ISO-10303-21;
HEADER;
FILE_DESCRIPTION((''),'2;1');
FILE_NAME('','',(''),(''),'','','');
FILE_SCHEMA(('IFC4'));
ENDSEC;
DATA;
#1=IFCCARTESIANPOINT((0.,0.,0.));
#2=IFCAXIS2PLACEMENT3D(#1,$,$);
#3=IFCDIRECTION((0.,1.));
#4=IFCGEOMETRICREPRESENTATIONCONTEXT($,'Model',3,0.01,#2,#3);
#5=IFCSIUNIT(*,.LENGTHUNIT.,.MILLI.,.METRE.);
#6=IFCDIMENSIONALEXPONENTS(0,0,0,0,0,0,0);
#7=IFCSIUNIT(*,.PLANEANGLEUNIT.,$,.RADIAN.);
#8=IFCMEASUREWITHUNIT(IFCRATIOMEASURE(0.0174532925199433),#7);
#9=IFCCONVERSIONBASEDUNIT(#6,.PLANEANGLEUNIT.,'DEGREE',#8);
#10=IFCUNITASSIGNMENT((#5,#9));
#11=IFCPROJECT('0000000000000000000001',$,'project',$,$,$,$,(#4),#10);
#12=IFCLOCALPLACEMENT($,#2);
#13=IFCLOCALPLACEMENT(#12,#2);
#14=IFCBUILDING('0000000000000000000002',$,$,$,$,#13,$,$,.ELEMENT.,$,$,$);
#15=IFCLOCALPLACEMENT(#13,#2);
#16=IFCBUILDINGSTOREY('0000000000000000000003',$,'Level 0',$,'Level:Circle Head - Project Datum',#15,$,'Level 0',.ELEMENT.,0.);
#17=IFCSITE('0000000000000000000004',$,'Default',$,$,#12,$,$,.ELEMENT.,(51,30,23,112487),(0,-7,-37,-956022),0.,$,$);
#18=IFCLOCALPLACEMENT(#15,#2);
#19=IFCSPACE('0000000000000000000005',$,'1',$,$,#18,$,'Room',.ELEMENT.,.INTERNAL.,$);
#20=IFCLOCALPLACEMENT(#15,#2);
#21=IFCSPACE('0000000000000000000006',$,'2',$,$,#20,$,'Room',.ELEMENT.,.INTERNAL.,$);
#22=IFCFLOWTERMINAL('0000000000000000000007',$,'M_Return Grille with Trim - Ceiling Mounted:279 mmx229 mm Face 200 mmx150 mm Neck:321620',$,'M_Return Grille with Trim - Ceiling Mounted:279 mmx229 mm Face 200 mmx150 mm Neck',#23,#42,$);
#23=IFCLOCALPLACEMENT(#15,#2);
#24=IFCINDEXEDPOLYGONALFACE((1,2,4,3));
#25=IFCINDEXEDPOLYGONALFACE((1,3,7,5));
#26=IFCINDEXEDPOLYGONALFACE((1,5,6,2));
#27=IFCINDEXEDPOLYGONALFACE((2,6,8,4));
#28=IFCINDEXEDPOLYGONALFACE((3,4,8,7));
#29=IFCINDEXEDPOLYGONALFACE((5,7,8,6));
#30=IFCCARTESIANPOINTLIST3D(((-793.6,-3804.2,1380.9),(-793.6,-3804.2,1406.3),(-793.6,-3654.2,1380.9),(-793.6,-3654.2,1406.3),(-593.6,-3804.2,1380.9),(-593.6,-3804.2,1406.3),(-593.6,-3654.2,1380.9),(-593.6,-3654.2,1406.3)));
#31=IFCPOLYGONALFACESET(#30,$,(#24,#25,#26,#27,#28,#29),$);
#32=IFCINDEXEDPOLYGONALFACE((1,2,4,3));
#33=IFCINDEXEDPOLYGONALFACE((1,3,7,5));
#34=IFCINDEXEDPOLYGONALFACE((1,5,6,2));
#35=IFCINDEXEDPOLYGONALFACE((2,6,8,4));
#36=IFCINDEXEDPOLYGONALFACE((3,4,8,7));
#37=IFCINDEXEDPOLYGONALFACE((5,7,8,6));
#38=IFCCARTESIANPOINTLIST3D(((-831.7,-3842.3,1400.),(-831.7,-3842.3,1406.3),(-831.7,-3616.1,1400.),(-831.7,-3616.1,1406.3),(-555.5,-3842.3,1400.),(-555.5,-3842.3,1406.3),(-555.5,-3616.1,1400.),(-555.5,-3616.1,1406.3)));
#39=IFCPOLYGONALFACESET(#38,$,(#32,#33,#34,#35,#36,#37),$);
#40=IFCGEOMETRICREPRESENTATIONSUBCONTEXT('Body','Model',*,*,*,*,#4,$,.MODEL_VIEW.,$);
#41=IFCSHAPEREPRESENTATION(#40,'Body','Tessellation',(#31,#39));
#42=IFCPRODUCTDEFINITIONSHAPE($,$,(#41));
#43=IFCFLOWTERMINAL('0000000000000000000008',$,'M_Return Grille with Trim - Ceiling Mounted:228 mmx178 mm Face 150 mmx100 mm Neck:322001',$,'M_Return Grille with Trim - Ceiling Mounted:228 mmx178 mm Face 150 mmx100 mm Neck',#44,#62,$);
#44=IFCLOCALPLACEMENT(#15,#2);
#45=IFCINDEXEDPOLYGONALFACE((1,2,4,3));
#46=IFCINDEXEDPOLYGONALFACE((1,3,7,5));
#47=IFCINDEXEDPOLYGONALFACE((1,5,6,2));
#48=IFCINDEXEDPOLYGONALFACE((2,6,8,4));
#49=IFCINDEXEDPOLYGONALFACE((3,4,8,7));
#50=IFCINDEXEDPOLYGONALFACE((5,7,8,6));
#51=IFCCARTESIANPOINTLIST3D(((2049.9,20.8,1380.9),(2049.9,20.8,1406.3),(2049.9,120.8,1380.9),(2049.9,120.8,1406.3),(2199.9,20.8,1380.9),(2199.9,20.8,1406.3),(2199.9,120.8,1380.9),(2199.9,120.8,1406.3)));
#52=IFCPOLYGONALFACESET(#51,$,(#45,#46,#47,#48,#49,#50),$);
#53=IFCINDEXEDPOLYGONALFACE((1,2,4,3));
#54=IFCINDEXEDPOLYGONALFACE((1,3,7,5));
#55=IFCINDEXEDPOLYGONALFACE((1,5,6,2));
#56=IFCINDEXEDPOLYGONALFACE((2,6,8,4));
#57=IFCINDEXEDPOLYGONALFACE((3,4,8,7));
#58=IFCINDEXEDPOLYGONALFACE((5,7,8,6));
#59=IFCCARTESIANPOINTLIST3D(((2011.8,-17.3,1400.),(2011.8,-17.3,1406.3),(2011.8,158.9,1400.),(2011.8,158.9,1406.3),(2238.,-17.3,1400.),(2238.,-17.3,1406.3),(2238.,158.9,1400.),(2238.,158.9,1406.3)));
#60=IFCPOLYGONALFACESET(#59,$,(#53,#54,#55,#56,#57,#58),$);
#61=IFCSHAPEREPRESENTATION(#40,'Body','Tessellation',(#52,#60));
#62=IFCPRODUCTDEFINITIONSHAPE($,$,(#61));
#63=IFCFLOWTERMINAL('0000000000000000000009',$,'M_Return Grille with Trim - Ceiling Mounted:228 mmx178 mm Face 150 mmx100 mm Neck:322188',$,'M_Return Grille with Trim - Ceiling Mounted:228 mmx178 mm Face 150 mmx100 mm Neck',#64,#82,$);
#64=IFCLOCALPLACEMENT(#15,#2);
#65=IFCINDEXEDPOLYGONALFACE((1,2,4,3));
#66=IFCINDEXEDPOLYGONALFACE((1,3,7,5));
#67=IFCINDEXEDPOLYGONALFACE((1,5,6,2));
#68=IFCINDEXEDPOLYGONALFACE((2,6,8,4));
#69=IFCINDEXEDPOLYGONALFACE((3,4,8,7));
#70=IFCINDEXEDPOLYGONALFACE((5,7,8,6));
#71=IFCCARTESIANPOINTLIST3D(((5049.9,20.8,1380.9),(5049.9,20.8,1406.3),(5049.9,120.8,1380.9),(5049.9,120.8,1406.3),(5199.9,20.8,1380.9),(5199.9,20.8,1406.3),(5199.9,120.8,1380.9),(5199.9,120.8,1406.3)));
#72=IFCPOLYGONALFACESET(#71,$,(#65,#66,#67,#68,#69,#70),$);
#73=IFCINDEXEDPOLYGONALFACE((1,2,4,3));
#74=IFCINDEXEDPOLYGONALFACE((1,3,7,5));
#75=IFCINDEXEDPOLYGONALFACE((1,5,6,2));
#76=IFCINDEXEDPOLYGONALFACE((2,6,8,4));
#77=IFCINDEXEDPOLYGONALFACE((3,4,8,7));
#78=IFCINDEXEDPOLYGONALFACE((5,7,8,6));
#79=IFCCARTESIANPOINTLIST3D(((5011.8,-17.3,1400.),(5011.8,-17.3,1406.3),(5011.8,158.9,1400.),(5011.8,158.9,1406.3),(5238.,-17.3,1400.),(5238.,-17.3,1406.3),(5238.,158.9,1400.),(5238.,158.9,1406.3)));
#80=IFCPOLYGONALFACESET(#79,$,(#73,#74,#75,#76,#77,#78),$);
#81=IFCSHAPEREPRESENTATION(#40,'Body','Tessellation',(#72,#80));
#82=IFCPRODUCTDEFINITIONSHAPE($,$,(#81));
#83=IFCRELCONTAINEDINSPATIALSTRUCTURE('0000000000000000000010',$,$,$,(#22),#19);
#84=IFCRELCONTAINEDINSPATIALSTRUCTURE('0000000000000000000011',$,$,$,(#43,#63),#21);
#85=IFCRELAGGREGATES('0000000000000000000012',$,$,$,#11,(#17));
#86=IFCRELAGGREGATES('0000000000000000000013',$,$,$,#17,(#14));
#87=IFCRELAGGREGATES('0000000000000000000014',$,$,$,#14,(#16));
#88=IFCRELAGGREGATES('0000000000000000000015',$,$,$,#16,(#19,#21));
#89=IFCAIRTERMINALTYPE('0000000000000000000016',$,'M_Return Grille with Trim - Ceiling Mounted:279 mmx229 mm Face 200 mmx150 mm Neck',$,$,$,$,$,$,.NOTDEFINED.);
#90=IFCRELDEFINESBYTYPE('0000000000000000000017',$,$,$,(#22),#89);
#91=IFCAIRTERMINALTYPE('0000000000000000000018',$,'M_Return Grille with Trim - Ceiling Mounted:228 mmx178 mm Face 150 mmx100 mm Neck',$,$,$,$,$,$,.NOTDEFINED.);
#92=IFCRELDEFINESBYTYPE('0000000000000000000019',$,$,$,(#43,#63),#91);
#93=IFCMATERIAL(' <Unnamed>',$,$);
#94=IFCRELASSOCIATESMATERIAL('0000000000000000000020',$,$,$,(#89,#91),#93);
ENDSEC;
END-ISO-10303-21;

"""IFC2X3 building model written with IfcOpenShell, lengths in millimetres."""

from ifc_helpers import new_model, entity, si_unit, converted_unit, direction, frame, frame_2d, origin, origin_2d_with_axis, place, context, subcontext, project, spatial, rectangle, extrude, source, transform, mapped, material, type_object, type_shapes, element, save


model = new_model("IFC2X3")

# Units and contexts
model_context = context("Model", 3, precision=0.01, world=origin(), true_north=direction((0.0, 1.0)))
body_context = subcontext(model_context, "Body", "Model", "MODEL_VIEW")
ifc_project = project(units=[si_unit("LENGTHUNIT", "METRE", prefix="MILLI"), converted_unit("PLANEANGLEUNIT", "DEGREE", entity("IfcRatioMeasure", 0.0174532925199433), si_unit("PLANEANGLEUNIT", "RADIAN"), dimensions=[0, 0, 0, 0, 0, 0, 0])], contexts=[model_context])

# Site, building, storey
site_placement = place(None, origin())
site = spatial("IfcSite", under=ifc_project, at=site_placement, Name="Default", CompositionType="ELEMENT", RefLatitude=(51, 30, 23, 112487), RefLongitude=(0, -7, -37, -956022), RefElevation=0.0)
building_placement = place(site_placement, origin())
building = spatial("IfcBuilding", under=site, at=building_placement, CompositionType="ELEMENT")
storey_placement = place(building_placement, origin())
storey = spatial("IfcBuildingStorey", under=building, at=storey_placement, Name="Level 0", ObjectType="Level:Circle Head - Project Datum", LongName="Level 0", CompositionType="ELEMENT", Elevation=0.0)

# Shared definitions
space_1_placement = place(storey_placement, origin())
space_1 = spatial("IfcSpace", under=storey, at=space_1_placement, Name="1", LongName="Room", CompositionType="ELEMENT", InteriorOrExteriorSpace="INTERNAL")

# Flow terminal
ifc_material_1 = material(Name=" <Unnamed>")
air_terminal_type_1 = type_object("IfcAirTerminalType", Name="M_Return Grille with Trim - Ceiling Mounted:279 mmx229 mm Face 200 mmx150 mm Neck", PredefinedType="NOTDEFINED", material=ifc_material_1)
shared_shape_1 = source(origin(), body_context, "Body", "SweptSolid", [
    extrude(rectangle(XDim=200.0, YDim=150.0, at=origin_2d_with_axis()), frame((0.0, 0.0, -19.1), z_axis=(0.0, 0.0, 1.0), x_axis=(-1.0, 0.0, 0.0)), (0.0, 0.0, 1.0), 25.4),
    extrude(rectangle(XDim=276.2, YDim=226.2, at=frame_2d((0.0, 0.0), x_axis=(1.0, 0.0))), frame((0.0, 0.0, 0.0), z_axis=(0.0, 0.0, 1.0), x_axis=(-1.0, 0.0, 0.0)), (0.0, 0.0, 1.0), 6.3),
])
type_shapes(air_terminal_type_1, [shared_shape_1])
for number, where, z_axis, x_axis, name in (
    (1, (-693.6, -3729.2, 1400.0), (0.0, 0.0, 1.0), (-1.0, 0.0, 0.0), "M_Return Grille with Trim - Ceiling Mounted:279 mmx229 mm Face 200 mmx150 mm Neck:321620"),
):
    element("IfcFlowTerminal", number, at=place(space_1_placement, frame(where, z_axis=z_axis, x_axis=x_axis)), inside=space_1, type_object=air_terminal_type_1, Name=name, ObjectType="M_Return Grille with Trim - Ceiling Mounted:279 mmx229 mm Face 200 mmx150 mm Neck", context=body_context, shape_type="MappedRepresentation", body=[
        mapped(shared_shape_1, transform((0.0, 0.0, 0.0), scale=1.0)),
    ])

# Shared definitions
space_2_placement = place(storey_placement, origin())
space_2 = spatial("IfcSpace", under=storey, at=space_2_placement, Name="2", LongName="Room", CompositionType="ELEMENT", InteriorOrExteriorSpace="INTERNAL")

# Flow terminals
air_terminal_type_2 = type_object("IfcAirTerminalType", Name="M_Return Grille with Trim - Ceiling Mounted:228 mmx178 mm Face 150 mmx100 mm Neck", PredefinedType="NOTDEFINED", material=ifc_material_1)
shared_shape_2 = source(origin(), body_context, "Body", "SweptSolid", [
    extrude(rectangle(XDim=150.0, YDim=100.0, at=origin_2d_with_axis()), frame((0.0, 0.0, -19.1), z_axis=(0.0, 0.0, 1.0), x_axis=(-1.0, 0.0, 0.0)), (0.0, 0.0, 1.0), 25.4),
    extrude(rectangle(XDim=226.2, YDim=176.2, at=origin_2d_with_axis()), frame((0.0, 0.0, 0.0), z_axis=(0.0, 0.0, 1.0), x_axis=(-1.0, 0.0, 0.0)), (0.0, 0.0, 1.0), 6.3),
])
type_shapes(air_terminal_type_2, [shared_shape_2])
for number, where, z_axis, x_axis, name in (
    (2, (2124.9, 70.8, 1400.0), (0.0, 0.0, 1.0), (-1.0, 0.0, 0.0), "M_Return Grille with Trim - Ceiling Mounted:228 mmx178 mm Face 150 mmx100 mm Neck:322001"),
    (3, (5124.9, 70.8, 1400.0), (0.0, 0.0, 1.0), (-1.0, 0.0, 0.0), "M_Return Grille with Trim - Ceiling Mounted:228 mmx178 mm Face 150 mmx100 mm Neck:322188"),
):
    element("IfcFlowTerminal", number, at=place(space_2_placement, frame(where, z_axis=z_axis, x_axis=x_axis)), inside=space_2, type_object=air_terminal_type_2, Name=name, ObjectType="M_Return Grille with Trim - Ceiling Mounted:228 mmx178 mm Face 150 mmx100 mm Neck", context=body_context, shape_type="MappedRepresentation", body=[
        mapped(shared_shape_2, transform((0.0, 0.0, 0.0), scale=1.0)),
    ])

save(model, "model.ifc")
